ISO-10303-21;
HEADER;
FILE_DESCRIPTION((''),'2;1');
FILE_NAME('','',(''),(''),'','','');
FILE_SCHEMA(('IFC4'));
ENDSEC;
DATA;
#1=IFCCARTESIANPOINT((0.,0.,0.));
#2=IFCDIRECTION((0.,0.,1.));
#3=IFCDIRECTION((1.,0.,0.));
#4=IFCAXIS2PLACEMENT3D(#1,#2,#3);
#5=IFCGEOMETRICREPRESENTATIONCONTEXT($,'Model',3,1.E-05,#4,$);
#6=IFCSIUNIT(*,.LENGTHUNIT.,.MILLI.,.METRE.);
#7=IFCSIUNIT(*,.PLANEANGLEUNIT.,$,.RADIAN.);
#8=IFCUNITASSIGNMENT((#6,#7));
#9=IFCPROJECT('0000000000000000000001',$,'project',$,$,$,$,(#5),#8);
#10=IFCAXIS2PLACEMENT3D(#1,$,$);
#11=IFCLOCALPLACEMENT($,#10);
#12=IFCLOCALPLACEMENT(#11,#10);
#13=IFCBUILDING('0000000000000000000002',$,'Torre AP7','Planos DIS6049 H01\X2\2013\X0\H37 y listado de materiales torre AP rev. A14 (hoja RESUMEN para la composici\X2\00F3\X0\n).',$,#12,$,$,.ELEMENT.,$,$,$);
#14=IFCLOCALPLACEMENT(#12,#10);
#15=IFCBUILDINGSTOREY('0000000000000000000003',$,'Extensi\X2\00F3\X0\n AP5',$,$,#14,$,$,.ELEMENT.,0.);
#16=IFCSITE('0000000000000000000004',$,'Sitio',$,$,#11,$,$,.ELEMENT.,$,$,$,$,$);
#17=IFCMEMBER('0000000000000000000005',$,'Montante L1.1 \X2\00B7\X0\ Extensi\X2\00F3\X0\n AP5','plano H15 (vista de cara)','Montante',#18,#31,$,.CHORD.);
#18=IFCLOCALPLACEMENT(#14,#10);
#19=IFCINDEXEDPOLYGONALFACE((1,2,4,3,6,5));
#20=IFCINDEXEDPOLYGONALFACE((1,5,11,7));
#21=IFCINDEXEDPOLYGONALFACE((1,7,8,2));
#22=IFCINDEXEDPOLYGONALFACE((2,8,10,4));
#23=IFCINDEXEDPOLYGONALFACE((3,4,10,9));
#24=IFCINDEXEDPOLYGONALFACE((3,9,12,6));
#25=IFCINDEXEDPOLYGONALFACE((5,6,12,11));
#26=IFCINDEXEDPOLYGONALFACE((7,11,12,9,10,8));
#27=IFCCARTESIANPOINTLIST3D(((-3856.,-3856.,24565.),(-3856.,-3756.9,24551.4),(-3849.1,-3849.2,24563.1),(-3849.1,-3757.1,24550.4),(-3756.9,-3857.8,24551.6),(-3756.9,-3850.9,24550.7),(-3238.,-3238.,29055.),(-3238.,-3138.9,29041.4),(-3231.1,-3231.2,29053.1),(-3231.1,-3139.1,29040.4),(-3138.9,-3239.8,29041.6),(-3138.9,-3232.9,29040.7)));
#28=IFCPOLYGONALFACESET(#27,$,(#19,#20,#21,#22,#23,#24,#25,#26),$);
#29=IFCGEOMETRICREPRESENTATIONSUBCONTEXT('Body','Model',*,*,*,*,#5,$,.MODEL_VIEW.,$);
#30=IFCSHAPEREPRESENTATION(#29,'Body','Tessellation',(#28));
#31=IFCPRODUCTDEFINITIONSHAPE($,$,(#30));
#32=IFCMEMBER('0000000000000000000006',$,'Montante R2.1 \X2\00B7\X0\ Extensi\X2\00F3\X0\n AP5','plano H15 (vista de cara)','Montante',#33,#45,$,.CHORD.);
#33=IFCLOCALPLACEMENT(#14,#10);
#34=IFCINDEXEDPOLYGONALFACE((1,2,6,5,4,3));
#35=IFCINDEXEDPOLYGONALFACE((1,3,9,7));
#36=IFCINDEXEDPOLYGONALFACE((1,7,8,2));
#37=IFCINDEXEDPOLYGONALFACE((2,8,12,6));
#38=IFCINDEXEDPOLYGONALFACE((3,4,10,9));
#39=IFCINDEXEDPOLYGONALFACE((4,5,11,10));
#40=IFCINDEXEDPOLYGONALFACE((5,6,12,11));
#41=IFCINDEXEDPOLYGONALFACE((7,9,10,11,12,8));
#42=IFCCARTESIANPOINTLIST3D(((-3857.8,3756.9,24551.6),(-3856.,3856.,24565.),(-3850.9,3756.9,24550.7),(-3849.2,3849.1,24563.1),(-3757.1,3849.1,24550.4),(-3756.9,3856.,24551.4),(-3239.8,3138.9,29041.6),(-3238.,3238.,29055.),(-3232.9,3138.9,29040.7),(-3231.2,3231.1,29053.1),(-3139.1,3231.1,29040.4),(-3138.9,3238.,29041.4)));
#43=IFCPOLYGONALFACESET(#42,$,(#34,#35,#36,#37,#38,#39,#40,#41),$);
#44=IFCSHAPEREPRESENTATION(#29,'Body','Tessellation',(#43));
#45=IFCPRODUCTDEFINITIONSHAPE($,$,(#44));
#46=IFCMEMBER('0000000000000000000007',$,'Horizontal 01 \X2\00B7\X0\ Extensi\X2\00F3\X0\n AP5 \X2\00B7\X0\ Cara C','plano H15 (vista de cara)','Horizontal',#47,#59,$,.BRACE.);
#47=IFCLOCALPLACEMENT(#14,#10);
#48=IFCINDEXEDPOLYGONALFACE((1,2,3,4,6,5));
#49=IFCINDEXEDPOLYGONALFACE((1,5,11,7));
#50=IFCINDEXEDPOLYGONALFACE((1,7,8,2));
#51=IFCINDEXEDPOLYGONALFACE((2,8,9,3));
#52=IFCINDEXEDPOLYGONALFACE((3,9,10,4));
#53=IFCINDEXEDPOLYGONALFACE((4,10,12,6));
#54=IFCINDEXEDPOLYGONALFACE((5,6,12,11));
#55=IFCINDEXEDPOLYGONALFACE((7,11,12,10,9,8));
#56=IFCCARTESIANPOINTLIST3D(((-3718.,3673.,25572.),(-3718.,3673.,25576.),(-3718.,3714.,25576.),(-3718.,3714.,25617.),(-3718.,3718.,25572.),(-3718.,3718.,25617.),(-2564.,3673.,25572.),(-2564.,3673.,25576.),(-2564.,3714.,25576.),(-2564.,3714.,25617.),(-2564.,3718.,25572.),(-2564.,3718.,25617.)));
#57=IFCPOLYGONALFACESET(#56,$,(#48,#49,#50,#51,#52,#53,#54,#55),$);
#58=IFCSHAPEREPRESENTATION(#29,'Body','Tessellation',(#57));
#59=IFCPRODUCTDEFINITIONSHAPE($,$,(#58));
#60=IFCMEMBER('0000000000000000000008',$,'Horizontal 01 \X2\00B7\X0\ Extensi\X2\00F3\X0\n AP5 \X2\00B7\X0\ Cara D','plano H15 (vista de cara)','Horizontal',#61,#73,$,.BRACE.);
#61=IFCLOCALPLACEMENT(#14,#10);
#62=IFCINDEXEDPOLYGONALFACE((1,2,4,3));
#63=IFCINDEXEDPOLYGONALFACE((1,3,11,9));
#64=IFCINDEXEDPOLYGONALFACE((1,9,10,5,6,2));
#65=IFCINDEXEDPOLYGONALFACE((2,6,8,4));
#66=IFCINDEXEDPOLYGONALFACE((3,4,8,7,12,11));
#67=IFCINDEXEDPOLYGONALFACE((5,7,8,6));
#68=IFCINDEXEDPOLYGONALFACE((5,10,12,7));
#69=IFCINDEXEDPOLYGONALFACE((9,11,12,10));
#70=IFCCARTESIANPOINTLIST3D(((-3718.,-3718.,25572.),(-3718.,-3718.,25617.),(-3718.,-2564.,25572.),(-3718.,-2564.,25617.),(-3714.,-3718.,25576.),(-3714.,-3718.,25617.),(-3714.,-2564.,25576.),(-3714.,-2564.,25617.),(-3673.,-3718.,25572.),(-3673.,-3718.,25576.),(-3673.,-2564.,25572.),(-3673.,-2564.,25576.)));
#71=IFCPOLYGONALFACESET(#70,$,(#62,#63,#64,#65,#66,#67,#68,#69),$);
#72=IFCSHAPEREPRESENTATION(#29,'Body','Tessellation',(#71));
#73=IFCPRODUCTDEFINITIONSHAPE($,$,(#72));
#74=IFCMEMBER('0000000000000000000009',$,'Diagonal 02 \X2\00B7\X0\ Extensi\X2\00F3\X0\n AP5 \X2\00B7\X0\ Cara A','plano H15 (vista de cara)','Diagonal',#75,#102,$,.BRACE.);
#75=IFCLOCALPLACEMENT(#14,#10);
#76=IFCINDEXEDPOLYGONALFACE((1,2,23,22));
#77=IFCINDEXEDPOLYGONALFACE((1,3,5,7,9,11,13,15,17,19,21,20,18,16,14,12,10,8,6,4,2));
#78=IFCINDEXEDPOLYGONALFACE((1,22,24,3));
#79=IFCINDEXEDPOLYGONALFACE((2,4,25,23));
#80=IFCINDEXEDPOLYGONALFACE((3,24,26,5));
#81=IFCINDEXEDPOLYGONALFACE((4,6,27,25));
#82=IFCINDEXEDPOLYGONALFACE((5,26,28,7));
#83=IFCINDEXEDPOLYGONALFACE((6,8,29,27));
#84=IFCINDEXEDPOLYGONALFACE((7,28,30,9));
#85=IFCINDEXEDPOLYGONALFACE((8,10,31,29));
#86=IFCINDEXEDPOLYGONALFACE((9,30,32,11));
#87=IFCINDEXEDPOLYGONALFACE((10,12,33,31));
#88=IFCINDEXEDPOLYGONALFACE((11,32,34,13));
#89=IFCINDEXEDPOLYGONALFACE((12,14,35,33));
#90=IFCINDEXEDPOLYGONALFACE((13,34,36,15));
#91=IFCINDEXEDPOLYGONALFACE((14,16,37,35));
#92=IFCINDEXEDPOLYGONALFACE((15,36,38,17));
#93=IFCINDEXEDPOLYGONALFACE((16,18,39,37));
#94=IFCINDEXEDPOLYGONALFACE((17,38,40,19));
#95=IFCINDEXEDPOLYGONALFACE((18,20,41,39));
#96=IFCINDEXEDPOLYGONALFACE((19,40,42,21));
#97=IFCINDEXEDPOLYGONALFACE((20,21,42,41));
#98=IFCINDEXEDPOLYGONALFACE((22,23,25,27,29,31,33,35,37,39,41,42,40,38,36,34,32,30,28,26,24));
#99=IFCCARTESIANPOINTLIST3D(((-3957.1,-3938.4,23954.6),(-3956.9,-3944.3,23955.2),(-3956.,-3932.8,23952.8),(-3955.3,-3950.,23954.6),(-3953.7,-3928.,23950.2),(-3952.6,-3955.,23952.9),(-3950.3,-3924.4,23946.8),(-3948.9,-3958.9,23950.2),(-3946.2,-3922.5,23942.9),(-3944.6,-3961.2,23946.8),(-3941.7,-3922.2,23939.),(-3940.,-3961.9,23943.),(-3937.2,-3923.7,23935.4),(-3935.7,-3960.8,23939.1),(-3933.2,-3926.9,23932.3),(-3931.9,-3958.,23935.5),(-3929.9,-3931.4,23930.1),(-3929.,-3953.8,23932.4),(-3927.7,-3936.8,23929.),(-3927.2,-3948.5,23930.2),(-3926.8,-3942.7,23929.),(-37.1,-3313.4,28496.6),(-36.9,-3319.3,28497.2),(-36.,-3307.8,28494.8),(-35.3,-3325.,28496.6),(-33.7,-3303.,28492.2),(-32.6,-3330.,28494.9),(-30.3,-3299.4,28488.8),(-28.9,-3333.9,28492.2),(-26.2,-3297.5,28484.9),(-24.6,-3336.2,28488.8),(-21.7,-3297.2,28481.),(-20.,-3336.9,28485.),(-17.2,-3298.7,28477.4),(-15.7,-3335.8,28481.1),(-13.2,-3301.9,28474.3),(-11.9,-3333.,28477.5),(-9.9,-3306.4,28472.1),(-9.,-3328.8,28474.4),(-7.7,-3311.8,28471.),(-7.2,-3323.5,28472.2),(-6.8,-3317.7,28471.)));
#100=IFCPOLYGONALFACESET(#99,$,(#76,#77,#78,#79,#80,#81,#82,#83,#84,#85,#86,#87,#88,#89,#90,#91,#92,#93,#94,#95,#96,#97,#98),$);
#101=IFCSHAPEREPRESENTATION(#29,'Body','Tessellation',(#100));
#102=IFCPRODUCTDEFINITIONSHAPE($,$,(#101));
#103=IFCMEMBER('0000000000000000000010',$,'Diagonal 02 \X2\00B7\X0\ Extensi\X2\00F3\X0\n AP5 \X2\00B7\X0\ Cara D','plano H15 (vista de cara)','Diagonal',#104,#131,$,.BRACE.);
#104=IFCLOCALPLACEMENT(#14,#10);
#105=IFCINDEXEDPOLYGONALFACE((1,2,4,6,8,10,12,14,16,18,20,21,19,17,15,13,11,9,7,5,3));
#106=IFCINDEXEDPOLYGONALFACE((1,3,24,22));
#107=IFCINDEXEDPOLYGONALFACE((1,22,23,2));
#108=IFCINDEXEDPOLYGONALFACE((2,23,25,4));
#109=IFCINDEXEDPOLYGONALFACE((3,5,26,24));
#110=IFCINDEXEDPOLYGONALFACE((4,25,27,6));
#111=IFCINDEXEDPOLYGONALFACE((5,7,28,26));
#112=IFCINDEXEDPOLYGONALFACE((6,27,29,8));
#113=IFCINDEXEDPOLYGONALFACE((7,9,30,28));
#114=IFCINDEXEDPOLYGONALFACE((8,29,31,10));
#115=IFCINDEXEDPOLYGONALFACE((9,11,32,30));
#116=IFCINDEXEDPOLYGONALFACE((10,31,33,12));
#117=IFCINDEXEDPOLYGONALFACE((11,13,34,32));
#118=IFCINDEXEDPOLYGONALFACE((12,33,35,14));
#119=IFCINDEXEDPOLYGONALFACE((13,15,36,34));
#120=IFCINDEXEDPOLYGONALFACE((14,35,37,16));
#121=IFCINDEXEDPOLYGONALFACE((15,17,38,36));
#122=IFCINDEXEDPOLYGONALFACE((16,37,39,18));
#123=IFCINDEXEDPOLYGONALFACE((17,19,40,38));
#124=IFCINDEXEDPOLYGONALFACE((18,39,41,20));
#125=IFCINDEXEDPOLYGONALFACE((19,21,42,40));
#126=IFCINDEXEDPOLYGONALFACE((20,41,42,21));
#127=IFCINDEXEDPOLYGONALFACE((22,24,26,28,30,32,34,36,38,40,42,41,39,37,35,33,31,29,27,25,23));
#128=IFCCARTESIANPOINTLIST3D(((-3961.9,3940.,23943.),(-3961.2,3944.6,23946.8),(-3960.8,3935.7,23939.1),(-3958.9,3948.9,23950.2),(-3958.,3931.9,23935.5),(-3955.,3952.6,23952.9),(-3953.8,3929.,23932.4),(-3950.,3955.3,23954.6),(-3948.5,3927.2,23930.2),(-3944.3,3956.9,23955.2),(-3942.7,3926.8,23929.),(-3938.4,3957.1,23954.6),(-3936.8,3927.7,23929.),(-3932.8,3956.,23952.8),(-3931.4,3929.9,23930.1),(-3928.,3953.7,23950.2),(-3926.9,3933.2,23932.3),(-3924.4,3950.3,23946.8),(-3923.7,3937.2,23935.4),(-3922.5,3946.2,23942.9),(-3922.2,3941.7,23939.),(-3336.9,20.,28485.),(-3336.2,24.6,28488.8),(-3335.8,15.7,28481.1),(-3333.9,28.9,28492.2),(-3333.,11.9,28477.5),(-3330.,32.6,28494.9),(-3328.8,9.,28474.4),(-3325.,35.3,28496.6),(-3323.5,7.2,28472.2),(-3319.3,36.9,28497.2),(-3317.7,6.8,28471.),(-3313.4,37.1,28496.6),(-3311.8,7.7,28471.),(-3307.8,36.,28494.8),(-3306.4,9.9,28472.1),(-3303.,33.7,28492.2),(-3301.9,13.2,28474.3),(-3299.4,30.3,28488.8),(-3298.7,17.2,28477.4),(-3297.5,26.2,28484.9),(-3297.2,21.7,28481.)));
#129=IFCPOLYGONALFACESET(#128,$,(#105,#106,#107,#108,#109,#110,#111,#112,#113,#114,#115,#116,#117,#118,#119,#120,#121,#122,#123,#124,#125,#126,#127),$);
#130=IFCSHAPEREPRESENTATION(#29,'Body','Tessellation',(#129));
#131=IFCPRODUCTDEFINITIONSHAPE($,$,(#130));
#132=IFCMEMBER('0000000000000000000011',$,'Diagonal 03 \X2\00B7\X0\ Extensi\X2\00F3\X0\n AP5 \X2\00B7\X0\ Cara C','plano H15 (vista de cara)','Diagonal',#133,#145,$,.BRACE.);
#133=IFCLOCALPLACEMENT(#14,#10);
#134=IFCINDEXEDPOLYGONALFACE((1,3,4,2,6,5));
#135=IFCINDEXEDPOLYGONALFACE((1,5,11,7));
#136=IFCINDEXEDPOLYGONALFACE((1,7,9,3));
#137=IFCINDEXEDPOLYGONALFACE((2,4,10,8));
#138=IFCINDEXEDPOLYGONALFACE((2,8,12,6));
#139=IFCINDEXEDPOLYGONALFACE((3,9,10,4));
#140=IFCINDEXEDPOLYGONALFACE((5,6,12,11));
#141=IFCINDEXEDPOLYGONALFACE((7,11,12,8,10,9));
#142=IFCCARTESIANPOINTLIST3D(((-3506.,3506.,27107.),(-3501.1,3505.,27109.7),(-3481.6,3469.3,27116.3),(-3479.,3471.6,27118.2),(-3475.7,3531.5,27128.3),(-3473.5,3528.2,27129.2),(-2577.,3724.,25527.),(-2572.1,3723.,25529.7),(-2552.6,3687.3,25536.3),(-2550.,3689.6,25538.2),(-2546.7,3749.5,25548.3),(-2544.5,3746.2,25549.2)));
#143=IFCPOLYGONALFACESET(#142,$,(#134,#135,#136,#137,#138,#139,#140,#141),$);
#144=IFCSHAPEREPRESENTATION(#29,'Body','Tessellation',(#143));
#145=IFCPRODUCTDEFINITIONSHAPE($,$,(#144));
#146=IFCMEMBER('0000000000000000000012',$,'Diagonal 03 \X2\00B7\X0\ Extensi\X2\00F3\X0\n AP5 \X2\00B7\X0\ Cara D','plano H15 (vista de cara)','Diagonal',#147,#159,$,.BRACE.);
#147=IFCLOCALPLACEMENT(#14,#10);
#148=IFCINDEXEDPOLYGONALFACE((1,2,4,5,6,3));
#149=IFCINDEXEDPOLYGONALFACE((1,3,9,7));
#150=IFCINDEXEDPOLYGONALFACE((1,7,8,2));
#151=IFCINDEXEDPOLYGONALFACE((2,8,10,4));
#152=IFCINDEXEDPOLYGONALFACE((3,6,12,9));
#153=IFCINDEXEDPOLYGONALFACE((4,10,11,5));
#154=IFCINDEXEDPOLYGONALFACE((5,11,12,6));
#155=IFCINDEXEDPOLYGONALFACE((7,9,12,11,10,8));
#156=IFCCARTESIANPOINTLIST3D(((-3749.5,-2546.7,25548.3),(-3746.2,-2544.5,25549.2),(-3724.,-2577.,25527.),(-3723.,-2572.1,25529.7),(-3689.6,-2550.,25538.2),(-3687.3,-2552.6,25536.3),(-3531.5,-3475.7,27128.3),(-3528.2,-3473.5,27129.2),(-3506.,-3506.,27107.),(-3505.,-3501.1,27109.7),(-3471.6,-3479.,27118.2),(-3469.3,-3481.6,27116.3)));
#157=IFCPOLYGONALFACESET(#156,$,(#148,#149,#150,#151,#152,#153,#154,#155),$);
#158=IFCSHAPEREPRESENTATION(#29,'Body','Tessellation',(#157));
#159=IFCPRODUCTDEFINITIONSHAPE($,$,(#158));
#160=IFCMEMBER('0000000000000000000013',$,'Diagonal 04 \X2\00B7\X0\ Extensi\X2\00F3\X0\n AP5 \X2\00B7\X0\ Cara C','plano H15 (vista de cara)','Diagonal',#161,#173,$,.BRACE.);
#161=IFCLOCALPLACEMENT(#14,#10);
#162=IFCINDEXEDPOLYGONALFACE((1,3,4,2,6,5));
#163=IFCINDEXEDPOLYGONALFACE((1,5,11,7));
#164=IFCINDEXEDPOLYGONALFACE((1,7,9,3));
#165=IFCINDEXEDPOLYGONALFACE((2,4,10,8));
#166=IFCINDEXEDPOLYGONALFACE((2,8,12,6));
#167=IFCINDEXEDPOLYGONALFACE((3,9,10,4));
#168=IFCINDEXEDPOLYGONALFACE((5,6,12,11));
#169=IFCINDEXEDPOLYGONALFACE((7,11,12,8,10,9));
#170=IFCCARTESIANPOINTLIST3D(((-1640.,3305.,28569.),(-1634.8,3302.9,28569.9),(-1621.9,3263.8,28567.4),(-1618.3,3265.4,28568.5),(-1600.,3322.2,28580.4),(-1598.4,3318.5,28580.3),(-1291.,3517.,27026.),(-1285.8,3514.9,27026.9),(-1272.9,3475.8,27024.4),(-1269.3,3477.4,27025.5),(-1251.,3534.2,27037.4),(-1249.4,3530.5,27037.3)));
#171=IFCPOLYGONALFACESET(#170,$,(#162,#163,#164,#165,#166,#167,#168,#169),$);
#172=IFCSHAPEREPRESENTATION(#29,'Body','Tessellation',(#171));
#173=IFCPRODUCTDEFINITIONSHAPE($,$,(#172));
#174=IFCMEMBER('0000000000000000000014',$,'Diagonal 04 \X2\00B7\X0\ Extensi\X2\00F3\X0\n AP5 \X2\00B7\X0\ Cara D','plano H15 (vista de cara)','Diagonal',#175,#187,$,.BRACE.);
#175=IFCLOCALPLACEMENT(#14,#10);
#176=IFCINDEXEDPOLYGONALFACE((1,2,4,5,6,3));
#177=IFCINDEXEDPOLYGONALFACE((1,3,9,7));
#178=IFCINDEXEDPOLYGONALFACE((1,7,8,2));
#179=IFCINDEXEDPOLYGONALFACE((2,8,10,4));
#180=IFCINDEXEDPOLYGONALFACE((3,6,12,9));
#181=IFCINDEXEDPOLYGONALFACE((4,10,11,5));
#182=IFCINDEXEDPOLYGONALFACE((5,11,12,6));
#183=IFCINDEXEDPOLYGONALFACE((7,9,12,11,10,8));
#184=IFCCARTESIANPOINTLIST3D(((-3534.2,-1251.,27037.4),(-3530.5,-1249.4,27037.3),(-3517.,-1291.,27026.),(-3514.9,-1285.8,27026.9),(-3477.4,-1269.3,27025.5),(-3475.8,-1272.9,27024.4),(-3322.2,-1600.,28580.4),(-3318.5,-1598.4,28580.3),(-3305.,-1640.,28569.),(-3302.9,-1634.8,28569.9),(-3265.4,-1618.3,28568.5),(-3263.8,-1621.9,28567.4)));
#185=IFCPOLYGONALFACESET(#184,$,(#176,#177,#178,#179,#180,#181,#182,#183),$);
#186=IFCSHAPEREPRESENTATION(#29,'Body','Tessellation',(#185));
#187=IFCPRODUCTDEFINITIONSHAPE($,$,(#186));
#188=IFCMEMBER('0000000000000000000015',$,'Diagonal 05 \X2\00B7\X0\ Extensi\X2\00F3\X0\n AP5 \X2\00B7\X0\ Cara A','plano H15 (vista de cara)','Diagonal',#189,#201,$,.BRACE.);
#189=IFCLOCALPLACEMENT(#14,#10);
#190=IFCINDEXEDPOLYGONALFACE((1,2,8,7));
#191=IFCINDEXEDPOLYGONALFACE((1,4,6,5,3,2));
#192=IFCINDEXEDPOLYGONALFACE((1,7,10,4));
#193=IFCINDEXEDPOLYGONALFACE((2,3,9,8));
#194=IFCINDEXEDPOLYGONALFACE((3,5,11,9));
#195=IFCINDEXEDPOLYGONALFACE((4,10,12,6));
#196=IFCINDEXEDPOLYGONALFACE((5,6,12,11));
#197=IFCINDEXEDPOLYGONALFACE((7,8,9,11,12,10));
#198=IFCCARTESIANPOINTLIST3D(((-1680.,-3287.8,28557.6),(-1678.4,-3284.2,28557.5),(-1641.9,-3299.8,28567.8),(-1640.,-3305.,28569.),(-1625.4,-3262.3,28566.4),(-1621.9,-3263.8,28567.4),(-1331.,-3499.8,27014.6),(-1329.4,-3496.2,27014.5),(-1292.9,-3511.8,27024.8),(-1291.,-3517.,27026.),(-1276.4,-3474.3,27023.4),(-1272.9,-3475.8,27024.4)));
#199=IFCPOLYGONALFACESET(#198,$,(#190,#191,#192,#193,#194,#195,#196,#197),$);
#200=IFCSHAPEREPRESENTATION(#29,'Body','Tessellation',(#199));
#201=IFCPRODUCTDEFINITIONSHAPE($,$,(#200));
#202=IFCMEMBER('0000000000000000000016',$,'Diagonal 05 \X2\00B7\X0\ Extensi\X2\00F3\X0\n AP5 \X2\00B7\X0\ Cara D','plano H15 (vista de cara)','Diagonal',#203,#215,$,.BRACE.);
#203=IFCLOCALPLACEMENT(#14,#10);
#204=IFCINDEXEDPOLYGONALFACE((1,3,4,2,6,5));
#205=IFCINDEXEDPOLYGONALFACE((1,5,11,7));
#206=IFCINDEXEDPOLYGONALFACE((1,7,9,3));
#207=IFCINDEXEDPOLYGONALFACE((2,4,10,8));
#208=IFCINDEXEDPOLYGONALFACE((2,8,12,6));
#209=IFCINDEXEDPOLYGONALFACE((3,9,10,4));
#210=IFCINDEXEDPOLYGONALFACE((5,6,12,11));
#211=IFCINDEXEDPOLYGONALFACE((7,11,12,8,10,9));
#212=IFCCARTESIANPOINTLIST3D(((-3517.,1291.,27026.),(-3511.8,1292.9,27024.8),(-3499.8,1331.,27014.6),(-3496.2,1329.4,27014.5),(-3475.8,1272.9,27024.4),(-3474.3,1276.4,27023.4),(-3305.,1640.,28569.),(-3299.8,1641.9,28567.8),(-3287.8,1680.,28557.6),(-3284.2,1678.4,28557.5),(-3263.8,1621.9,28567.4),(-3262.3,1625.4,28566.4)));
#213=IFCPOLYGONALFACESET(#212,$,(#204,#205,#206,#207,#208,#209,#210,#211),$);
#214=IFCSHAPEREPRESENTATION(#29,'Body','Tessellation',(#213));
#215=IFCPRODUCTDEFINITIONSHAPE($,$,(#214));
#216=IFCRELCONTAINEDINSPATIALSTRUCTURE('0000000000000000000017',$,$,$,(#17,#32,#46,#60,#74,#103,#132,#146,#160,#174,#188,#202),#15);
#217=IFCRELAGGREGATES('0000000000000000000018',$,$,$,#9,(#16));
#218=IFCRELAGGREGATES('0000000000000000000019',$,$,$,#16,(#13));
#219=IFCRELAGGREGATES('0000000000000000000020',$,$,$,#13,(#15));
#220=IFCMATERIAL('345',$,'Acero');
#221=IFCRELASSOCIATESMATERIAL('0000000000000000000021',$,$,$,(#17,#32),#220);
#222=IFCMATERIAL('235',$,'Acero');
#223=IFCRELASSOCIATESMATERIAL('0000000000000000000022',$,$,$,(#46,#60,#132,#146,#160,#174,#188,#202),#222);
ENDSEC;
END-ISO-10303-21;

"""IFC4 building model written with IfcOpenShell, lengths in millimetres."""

from ifc_helpers import new_model, si_unit, frame, frame_2d, origin, origin_with_axes, place, context, subcontext, project, spatial, circle, l_section, extrude, material, element, save


model = new_model("IFC4")

# Units and contexts
model_context = context("Model", 3, precision=1e-05, world=origin_with_axes())
body_context = subcontext(model_context, "Body", "Model", "MODEL_VIEW")
ifc_project = project(units=[si_unit("LENGTHUNIT", "METRE", prefix="MILLI"), si_unit("PLANEANGLEUNIT", "RADIAN")], contexts=[model_context])

# Site, building, storey
site_placement = place(None, origin())
site = spatial("IfcSite", under=ifc_project, at=site_placement, Name="Sitio", CompositionType="ELEMENT")
building_placement = place(site_placement, origin())
building = spatial("IfcBuilding", under=site, at=building_placement, Name="Torre AP7", Description="Planos DIS6049 H01–H37 y listado de materiales torre AP rev. A14 (hoja RESUMEN para la composición).", CompositionType="ELEMENT")
storey_placement = place(building_placement, origin())
storey = spatial("IfcBuildingStorey", under=building, at=storey_placement, Name="Extensión AP5", CompositionType="ELEMENT", Elevation=0.0)

# Members
ifc_material_1 = material(Name="345", Category="Acero")
for number, where, z_axis, x_axis, name in (
    (1, (-3856.0, -3856.0, 24565.0), (0.135104, 0.135104, 0.981577), (0.990831, -0.018422, -0.133842), "Montante L1.1 · Extensión AP5"),
    (2, (-3856.0, 3856.0, 24565.0), (0.135104, -0.135104, 0.981577), (-0.018422, -0.990831, -0.133842), "Montante R2.1 · Extensión AP5"),
):
    element("IfcMember", number, at=place(storey_placement, frame(where, z_axis=z_axis, x_axis=x_axis)), inside=storey, material=ifc_material_1, Name=name, Description="plano H15 (vista de cara)", ObjectType="Montante", PredefinedType="CHORD", context=body_context, shape_type="SweptSolid", body=[
        extrude(l_section(Depth=100.0, Width=100.0, Thickness=7.0, at=frame_2d((50.0, 50.0))), None, (0.0, 0.0, 1.0), 4574.3),
    ])
ifc_material_2 = material(Name="235", Category="Acero")
for number, where, z_axis, x_axis, name in (
    (3, (-2564.0, 3718.0, 25572.0), (-1.0, 0.0, 0.0), (0.0, -1.0, 0.0), "Horizontal 01 · Extensión AP5 · Cara C"),
    (4, (-3718.0, -2564.0, 25572.0), (0.0, -1.0, 0.0), (1.0, 0.0, 0.0), "Horizontal 01 · Extensión AP5 · Cara D"),
):
    element("IfcMember", number, at=place(storey_placement, frame(where, z_axis=z_axis, x_axis=x_axis)), inside=storey, material=ifc_material_2, Name=name, Description="plano H15 (vista de cara)", ObjectType="Horizontal", PredefinedType="BRACE", context=body_context, shape_type="SweptSolid", body=[
        extrude(l_section(Depth=45.0, Width=45.0, Thickness=4.0, at=frame_2d((22.5, 22.5))), None, (0.0, 0.0, 1.0), 1154.0),
    ])
for number, where, z_axis, x_axis, name in (
    (5, (-3942.0, -3942.0, 23942.0), (0.649852, 0.103612, 0.752966), (0.237889, 0.913165, -0.330967), "Diagonal 02 · Extensión AP5 · Cara A"),
    (6, (-3942.0, 3942.0, 23942.0), (0.103612, -0.649852, 0.752966), (0.913165, -0.237889, -0.330967), "Diagonal 02 · Extensión AP5 · Cara D"),
):
    element("IfcMember", number, at=place(storey_placement, frame(where, z_axis=z_axis, x_axis=x_axis)), inside=storey, Name=name, Description="plano H15 (vista de cara)", ObjectType="Diagonal", PredefinedType="BRACE", context=body_context, shape_type="SweptSolid", body=[
        extrude(circle(Radius=20.0), None, (0.0, 0.0, 1.0), 6032.1),
    ])
for number, where, z_axis, x_axis, name in (
    (7, (-2577.0, 3724.0, 25527.0), (-0.503306, -0.118106, 0.855999), (0.541181, -0.815359, 0.205702), "Diagonal 03 · Extensión AP5 · Cara C"),
    (8, (-3724.0, -2577.0, 25527.0), (0.118106, -0.503306, 0.855999), (0.815359, 0.541181, 0.205702), "Diagonal 03 · Extensión AP5 · Cara D"),
):
    element("IfcMember", number, at=place(storey_placement, frame(where, z_axis=z_axis, x_axis=x_axis)), inside=storey, material=ifc_material_2, Name=name, Description="plano H15 (vista de cara)", ObjectType="Diagonal", PredefinedType="BRACE", context=body_context, shape_type="SweptSolid", body=[
        extrude(l_section(Depth=45.0, Width=45.0, Thickness=4.0, at=frame_2d((22.5, 22.5))), None, (0.0, 0.0, 1.0), 1845.8),
    ])
for number, where, z_axis, x_axis, name in (
    (9, (-1291.0, 3517.0, 27026.0), (-0.218655, -0.132822, 0.96672), (0.402816, -0.914628, -0.034555), "Diagonal 04 · Extensión AP5 · Cara C"),
    (10, (-3517.0, -1291.0, 27026.0), (0.132822, -0.218655, 0.96672), (0.914628, 0.402816, -0.034555), "Diagonal 04 · Extensión AP5 · Cara D"),
    (11, (-1291.0, -3517.0, 27026.0), (-0.218655, 0.132822, 0.96672), (0.402816, 0.914628, -0.034555), "Diagonal 05 · Extensión AP5 · Cara A"),
    (12, (-3517.0, 1291.0, 27026.0), (0.132822, 0.218655, 0.96672), (0.914628, -0.402816, -0.034555), "Diagonal 05 · Extensión AP5 · Cara D"),
):
    element("IfcMember", number, at=place(storey_placement, frame(where, z_axis=z_axis, x_axis=x_axis)), inside=storey, material=ifc_material_2, Name=name, Description="plano H15 (vista de cara)", ObjectType="Diagonal", PredefinedType="BRACE", context=body_context, shape_type="SweptSolid", body=[
        extrude(l_section(Depth=45.0, Width=45.0, Thickness=4.0, at=frame_2d((22.5, 22.5))), None, (0.0, 0.0, 1.0), 1596.1),
    ])

save(model, "model.ifc")
